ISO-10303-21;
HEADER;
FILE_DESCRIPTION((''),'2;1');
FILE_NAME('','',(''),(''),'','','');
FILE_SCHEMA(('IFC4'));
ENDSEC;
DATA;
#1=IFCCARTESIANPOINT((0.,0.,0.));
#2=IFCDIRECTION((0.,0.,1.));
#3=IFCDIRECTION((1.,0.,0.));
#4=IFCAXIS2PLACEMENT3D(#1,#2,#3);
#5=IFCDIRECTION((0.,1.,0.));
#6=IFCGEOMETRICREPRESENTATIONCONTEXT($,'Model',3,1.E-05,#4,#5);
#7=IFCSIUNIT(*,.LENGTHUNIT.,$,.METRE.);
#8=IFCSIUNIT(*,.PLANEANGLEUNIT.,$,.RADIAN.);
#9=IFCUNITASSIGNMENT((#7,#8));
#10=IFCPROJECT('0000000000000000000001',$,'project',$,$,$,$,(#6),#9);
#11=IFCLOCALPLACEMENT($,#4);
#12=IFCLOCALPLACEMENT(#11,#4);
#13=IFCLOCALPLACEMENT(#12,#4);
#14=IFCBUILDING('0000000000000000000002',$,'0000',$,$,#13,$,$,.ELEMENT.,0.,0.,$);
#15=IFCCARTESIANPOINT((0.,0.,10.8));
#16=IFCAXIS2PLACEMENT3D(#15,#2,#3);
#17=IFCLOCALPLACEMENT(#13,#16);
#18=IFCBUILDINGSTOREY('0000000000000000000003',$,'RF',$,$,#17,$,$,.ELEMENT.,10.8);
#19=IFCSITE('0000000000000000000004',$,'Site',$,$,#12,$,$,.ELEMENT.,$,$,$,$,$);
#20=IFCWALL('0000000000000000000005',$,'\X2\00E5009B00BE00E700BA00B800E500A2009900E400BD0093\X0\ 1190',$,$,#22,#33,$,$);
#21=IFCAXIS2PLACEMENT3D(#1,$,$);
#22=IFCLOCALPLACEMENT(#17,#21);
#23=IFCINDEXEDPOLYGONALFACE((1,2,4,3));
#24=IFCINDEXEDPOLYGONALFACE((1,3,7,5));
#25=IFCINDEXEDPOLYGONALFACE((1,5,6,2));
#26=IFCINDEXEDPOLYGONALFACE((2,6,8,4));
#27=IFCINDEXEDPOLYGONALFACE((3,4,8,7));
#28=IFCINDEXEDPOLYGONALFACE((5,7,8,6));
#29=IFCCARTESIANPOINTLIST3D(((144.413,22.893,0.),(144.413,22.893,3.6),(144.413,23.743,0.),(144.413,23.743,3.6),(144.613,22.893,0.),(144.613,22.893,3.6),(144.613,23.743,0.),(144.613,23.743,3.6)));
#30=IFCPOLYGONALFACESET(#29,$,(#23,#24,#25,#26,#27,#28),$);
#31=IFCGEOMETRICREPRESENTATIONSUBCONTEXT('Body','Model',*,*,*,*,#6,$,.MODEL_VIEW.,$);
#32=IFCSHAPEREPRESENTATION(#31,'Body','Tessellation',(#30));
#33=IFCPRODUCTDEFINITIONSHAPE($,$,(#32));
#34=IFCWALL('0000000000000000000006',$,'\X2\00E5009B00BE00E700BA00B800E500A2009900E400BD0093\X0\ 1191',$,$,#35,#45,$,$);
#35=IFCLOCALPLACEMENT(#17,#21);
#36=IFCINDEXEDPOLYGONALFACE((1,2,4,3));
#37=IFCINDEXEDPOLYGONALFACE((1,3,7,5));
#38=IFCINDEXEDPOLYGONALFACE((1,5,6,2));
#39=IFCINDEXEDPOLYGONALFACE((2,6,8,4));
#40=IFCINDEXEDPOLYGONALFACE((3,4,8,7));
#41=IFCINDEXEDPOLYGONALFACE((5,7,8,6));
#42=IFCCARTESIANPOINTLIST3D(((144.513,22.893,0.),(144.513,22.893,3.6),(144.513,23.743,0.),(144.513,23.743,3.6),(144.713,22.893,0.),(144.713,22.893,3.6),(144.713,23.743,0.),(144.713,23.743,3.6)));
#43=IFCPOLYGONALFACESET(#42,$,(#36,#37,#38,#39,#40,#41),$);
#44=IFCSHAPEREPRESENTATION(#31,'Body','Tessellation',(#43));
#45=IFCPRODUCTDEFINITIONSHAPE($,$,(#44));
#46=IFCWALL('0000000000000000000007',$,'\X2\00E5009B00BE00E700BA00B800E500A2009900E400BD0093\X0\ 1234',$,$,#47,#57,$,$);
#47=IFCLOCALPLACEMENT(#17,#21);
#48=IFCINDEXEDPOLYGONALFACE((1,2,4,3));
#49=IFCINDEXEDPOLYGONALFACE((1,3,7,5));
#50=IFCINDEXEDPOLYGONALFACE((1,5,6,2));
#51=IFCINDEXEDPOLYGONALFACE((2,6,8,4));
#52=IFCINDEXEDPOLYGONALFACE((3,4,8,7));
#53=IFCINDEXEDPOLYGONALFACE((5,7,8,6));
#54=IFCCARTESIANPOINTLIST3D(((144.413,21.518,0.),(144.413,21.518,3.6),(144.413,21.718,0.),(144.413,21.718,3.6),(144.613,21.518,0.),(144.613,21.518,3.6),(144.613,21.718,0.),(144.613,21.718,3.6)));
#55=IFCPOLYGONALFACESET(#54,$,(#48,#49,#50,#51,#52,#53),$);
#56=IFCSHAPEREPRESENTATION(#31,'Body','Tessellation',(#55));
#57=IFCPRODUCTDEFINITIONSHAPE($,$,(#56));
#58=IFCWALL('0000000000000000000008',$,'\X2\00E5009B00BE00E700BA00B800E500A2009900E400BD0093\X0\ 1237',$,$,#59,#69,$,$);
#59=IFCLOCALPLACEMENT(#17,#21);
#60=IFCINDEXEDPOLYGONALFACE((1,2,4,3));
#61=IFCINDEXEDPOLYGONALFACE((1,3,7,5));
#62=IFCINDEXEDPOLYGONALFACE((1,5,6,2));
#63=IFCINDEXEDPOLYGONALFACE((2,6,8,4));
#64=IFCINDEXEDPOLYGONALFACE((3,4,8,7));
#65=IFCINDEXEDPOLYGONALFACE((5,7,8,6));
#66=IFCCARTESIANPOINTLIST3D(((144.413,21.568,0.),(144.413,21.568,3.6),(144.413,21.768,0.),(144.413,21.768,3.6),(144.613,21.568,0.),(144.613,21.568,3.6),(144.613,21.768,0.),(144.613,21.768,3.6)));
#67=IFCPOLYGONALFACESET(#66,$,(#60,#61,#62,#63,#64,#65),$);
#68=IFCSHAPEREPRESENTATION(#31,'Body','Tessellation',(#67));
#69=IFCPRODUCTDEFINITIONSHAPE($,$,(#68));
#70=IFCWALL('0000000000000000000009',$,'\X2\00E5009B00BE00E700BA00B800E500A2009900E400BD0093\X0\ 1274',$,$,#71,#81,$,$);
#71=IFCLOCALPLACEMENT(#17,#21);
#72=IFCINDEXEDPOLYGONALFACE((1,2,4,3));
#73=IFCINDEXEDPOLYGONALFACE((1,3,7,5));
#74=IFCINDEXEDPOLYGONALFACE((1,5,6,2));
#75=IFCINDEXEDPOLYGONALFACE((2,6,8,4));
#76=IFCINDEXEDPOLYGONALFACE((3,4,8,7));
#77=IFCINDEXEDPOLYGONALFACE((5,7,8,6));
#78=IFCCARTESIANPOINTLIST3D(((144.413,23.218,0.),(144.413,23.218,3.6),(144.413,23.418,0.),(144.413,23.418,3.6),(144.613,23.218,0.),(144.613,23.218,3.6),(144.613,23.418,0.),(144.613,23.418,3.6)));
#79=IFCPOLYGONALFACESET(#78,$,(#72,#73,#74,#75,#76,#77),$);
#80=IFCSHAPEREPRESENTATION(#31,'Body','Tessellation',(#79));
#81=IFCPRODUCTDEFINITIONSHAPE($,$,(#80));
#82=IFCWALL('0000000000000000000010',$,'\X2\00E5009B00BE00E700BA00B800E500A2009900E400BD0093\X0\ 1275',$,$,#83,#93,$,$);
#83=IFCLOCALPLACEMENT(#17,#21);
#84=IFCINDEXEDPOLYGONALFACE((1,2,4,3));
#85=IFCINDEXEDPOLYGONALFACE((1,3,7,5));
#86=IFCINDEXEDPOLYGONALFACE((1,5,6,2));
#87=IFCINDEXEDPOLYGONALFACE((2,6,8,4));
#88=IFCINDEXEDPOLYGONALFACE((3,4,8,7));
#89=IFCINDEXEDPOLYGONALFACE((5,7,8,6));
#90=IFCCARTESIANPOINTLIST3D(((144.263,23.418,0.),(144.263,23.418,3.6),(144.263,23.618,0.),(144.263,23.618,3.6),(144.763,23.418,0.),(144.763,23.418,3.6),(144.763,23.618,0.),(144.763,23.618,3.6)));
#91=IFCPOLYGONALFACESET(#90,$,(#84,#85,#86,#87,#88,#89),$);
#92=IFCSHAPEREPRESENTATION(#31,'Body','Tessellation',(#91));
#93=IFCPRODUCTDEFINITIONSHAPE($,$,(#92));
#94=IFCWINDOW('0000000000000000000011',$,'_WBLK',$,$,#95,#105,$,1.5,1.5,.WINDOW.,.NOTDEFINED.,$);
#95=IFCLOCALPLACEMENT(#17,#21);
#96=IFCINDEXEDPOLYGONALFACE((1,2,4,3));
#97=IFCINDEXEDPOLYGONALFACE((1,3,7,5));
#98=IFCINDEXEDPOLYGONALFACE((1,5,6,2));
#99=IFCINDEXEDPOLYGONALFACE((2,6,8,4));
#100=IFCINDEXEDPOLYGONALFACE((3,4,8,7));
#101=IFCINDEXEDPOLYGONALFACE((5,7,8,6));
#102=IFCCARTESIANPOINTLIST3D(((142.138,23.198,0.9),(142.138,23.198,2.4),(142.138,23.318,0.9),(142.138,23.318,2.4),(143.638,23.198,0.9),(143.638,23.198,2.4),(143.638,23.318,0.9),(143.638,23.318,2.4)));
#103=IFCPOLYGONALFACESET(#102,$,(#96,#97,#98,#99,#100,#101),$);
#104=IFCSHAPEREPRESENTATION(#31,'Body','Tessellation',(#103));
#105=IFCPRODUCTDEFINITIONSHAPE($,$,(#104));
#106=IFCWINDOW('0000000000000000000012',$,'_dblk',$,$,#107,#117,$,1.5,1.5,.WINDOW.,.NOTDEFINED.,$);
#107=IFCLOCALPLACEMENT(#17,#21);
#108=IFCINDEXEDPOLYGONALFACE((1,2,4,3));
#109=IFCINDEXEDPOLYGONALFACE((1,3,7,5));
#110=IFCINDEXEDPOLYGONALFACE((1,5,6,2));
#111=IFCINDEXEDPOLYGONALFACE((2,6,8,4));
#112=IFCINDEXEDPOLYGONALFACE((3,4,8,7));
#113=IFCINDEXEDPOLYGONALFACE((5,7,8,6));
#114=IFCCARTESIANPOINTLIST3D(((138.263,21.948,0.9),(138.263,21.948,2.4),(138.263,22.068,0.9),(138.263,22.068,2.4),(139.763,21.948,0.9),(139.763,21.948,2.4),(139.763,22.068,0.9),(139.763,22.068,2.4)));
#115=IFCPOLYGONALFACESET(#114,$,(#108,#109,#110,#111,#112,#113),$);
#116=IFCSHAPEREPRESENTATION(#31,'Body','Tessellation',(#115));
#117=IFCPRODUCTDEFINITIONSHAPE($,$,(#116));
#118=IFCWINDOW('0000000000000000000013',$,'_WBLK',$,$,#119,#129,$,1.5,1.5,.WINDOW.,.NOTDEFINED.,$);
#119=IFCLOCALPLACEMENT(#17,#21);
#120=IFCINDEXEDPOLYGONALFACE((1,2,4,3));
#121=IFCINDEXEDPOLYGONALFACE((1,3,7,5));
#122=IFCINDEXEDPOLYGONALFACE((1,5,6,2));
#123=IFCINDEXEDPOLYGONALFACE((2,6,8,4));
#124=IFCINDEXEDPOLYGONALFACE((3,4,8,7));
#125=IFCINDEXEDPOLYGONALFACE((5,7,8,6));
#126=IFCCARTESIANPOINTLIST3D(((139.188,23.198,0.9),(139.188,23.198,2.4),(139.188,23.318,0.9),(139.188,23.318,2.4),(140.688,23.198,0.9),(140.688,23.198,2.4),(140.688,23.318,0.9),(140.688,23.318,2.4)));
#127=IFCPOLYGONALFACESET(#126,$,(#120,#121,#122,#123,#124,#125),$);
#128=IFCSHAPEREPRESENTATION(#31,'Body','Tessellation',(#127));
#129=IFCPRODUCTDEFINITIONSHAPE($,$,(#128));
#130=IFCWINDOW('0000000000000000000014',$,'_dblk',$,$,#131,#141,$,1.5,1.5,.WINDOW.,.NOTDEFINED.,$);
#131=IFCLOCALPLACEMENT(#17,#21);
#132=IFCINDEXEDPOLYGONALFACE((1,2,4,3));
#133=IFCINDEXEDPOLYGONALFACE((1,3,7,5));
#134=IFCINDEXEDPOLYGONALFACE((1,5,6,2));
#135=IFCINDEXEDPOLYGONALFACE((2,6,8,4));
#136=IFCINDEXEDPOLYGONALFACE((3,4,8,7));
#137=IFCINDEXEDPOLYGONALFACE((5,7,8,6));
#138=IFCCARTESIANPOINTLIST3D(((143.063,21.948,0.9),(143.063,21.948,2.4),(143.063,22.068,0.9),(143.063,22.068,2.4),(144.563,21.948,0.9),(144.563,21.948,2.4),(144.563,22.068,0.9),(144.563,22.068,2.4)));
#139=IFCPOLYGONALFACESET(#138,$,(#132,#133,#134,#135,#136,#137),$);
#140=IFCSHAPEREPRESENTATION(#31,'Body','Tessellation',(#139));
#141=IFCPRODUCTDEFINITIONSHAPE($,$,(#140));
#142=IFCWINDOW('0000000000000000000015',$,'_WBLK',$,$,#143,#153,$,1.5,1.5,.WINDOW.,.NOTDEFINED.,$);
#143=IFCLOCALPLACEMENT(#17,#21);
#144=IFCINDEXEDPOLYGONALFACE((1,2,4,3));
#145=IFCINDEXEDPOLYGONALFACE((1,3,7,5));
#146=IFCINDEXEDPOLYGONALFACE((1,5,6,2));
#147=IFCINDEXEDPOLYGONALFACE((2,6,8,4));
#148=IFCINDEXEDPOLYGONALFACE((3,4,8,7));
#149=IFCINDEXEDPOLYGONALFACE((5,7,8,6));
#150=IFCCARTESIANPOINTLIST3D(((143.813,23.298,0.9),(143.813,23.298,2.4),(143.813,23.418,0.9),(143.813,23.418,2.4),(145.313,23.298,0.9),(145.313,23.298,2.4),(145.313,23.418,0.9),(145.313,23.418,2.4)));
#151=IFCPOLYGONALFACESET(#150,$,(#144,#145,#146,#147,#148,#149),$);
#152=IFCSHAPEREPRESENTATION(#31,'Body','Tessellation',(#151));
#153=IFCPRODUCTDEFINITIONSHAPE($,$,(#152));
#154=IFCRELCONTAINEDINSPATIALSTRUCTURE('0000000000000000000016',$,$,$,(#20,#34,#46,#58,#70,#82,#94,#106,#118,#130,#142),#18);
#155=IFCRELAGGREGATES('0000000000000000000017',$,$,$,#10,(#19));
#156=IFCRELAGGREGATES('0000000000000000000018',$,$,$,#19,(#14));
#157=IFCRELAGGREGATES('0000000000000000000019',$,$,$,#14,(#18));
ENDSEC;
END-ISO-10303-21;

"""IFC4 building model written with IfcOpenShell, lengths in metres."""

from ifc_helpers import new_model, si_unit, direction, frame, frame_2d, origin_with_axes, place, context, subcontext, project, spatial, rectangle, extrude, element, save


model = new_model("IFC4")

# Units and contexts
model_context = context("Model", 3, precision=1e-05, world=origin_with_axes(), true_north=direction((0.0, 1.0, 0.0)))
body_context = subcontext(model_context, "Body", "Model", "MODEL_VIEW")
ifc_project = project(units=[si_unit("LENGTHUNIT", "METRE"), si_unit("PLANEANGLEUNIT", "RADIAN")], contexts=[model_context])

# Site, building, storey
placement = place(None, origin_with_axes())
site_placement = place(placement, origin_with_axes())
site = spatial("IfcSite", under=ifc_project, at=site_placement, Name="Site", CompositionType="ELEMENT")
building_placement = place(site_placement, origin_with_axes())
building = spatial("IfcBuilding", under=site, at=building_placement, Name="0000", CompositionType="ELEMENT", ElevationOfRefHeight=0.0, ElevationOfTerrain=0.0)
storey_placement = place(building_placement, frame((0.0, 0.0, 10.8), z_axis=(0.0, 0.0, 1.0), x_axis=(1.0, 0.0, 0.0)))
storey = spatial("IfcBuildingStorey", under=building, at=storey_placement, Name="RF", CompositionType="ELEMENT", Elevation=10.8)

# Walls
for number, where, z_axis, x_axis, name in (
    (1, (144.513, 23.318, 0.0), (0.0, 0.0, 1.0), (0.0, -1.0, 0.0), "å\u009b¾çº¸å¢\u0099ä½\u0093 1190"),
    (2, (144.613, 23.318, 0.0), (0.0, 0.0, 1.0), (0.0, -1.0, 0.0), "å\u009b¾çº¸å¢\u0099ä½\u0093 1191"),
):
    element("IfcWall", number, at=place(storey_placement, frame(where, z_axis=z_axis, x_axis=x_axis)), inside=storey, Name=name, context=body_context, shape_type="SweptSolid", body=[
        extrude(rectangle(XDim=0.85, YDim=0.2, at=frame_2d((0.0, 0.0), x_axis=(1.0, 0.0, 0.0))), frame((0.0, 0.0, 0.0), z_axis=(0.0, 0.0, 1.0)), (0.0, 0.0, 1.0), 3.6),
    ])
for number, where, z_axis, x_axis, name in (
    (3, (144.513, 21.618, 0.0), (0.0, 0.0, 1.0), (0.0, -1.0, 0.0), "å\u009b¾çº¸å¢\u0099ä½\u0093 1234"),
    (4, (144.513, 21.668, 0.0), (0.0, 0.0, 1.0), (0.0, -1.0, 0.0), "å\u009b¾çº¸å¢\u0099ä½\u0093 1237"),
    (5, (144.513, 23.318, 0.0), (0.0, 0.0, 1.0), (0.0, 1.0, 0.0), "å\u009b¾çº¸å¢\u0099ä½\u0093 1274"),
):
    element("IfcWall", number, at=place(storey_placement, frame(where, z_axis=z_axis, x_axis=x_axis)), inside=storey, Name=name, context=body_context, shape_type="SweptSolid", body=[
        extrude(rectangle(XDim=0.2, YDim=0.2, at=frame_2d((0.0, 0.0), x_axis=(1.0, 0.0, 0.0))), frame((0.0, 0.0, 0.0), z_axis=(0.0, 0.0, 1.0)), (0.0, 0.0, 1.0), 3.6),
    ])
wall_1_placement = place(storey_placement, frame((144.513, 23.518, 0.0), z_axis=(0.0, 0.0, 1.0), x_axis=(1.0, 0.0, 0.0)))
element("IfcWall", 6, at=wall_1_placement, inside=storey, Name="å\u009b¾çº¸å¢\u0099ä½\u0093 1275", context=body_context, shape_type="SweptSolid", body=[
    extrude(rectangle(XDim=0.5, YDim=0.2, at=frame_2d((0.0, 0.0), x_axis=(1.0, 0.0, 0.0))), frame((0.0, 0.0, 0.0), z_axis=(0.0, 0.0, 1.0)), (0.0, 0.0, 1.0), 3.6),
])

# Windows
for number, where, z_axis, x_axis, name in (
    (7, (142.888, 23.258, 0.9), (0.0, 0.0, 1.0), (1.0, 0.0, 0.0), "_WBLK"),
    (8, (139.013, 22.008, 0.9), (0.0, 0.0, 1.0), (1.0, 0.0, 0.0), "_dblk"),
    (9, (139.938, 23.258, 0.9), (0.0, 0.0, 1.0), (1.0, 0.0, 0.0), "_WBLK"),
    (10, (143.813, 22.008, 0.9), (0.0, 0.0, 1.0), (1.0, 0.0, 0.0), "_dblk"),
    (11, (144.563, 23.358, 0.9), (0.0, 0.0, 1.0), (1.0, 0.0, 0.0), "_WBLK"),
):
    element("IfcWindow", number, at=place(storey_placement, frame(where, z_axis=z_axis, x_axis=x_axis)), inside=storey, Name=name, OverallHeight=1.5, OverallWidth=1.5, PartitioningType="NOTDEFINED", PredefinedType="WINDOW", context=body_context, shape_type="SweptSolid", body=[
        extrude(rectangle(XDim=1.5, YDim=0.12, at=frame_2d((0.0, 0.0), x_axis=(1.0, 0.0, 0.0))), frame((0.0, 0.0, 0.0), z_axis=(0.0, 0.0, 1.0)), (0.0, 0.0, 1.0), 1.5),
    ])

save(model, "model.ifc")
